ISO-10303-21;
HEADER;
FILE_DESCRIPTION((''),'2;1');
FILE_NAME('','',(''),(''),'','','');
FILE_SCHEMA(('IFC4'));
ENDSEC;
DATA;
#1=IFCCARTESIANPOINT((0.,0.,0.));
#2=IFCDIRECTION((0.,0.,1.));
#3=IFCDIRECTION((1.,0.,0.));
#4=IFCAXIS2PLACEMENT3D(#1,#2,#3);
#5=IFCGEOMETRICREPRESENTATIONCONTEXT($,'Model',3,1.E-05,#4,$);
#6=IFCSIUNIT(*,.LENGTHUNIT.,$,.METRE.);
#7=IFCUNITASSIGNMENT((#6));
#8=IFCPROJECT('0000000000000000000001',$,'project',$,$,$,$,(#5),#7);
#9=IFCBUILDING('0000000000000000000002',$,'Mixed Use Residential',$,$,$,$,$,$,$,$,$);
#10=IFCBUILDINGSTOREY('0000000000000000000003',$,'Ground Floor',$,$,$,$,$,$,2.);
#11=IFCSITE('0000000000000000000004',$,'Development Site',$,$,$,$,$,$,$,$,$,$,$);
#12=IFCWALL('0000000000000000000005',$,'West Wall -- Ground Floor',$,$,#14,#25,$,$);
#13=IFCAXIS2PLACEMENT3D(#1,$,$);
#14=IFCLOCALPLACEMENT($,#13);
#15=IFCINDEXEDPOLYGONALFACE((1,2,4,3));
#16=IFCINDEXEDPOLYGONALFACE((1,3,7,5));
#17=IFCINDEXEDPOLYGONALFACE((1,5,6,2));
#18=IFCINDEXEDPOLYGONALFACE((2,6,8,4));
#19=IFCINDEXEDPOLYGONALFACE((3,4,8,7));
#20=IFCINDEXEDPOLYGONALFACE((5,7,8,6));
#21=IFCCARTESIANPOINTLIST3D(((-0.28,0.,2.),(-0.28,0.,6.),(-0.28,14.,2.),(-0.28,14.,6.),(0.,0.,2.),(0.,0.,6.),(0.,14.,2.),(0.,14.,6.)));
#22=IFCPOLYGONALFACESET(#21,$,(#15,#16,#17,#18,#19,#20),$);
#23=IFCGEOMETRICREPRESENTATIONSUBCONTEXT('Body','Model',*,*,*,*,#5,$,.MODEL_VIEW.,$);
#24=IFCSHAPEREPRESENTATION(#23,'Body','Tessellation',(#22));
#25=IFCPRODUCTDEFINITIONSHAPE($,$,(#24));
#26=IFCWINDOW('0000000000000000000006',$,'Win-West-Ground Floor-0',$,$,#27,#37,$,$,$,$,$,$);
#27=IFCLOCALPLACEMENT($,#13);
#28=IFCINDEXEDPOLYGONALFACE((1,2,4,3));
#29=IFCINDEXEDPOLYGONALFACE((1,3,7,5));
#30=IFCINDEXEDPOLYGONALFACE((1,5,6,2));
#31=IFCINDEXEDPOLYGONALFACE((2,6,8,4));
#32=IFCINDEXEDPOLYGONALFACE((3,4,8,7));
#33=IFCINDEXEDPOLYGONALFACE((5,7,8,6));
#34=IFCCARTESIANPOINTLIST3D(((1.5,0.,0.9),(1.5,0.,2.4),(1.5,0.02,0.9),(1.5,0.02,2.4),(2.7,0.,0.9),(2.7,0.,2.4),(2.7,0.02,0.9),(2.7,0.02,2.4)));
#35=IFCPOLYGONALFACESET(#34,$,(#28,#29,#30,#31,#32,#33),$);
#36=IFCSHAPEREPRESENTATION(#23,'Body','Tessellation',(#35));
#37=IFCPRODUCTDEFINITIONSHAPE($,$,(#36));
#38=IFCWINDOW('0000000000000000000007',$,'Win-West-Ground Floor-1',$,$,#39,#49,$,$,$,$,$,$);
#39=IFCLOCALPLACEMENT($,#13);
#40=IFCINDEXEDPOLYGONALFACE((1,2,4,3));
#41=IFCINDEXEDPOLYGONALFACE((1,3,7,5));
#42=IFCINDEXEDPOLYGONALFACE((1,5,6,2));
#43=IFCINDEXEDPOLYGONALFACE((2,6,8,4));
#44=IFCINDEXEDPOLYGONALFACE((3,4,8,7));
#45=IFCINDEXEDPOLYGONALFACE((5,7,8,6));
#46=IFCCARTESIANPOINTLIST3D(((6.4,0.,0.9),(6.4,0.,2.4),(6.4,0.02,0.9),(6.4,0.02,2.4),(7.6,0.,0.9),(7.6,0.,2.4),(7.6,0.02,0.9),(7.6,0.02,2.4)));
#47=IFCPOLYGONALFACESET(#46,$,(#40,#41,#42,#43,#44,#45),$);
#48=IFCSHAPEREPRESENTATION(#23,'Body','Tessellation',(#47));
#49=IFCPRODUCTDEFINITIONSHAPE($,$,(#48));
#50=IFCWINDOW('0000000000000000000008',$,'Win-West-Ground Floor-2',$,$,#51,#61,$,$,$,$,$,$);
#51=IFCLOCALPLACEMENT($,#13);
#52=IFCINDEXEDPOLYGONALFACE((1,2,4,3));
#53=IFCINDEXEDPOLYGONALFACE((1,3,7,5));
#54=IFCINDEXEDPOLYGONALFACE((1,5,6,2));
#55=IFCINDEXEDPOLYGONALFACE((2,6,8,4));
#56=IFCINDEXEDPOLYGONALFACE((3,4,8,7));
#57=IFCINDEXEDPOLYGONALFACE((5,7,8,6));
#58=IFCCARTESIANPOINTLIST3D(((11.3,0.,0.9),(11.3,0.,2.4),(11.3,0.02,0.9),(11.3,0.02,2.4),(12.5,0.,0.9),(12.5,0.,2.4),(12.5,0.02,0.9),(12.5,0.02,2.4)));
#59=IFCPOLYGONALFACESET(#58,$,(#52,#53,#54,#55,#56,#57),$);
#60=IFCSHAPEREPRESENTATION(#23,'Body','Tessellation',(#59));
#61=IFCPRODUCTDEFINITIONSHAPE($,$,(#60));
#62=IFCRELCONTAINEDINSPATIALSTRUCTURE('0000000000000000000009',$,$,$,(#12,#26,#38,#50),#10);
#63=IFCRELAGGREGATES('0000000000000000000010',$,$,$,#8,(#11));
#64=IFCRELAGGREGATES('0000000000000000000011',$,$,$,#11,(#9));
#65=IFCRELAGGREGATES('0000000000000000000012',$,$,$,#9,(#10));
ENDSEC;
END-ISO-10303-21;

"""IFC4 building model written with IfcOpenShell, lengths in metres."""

from ifc_helpers import new_model, si_unit, frame, origin_with_axes, place, context, subcontext, project, spatial, indexed_curve, outline, extrude, element, fill, save


model = new_model("IFC4")

# Units and contexts
model_context = context("Model", 3, precision=1e-05, world=origin_with_axes())
body_context = subcontext(model_context, "Body", "Model", "MODEL_VIEW")
ifc_project = project(units=[si_unit("LENGTHUNIT", "METRE")], contexts=[model_context])

# Site, building, storey
site = spatial("IfcSite", under=ifc_project, Name="Development Site")
building = spatial("IfcBuilding", under=site, Name="Mixed Use Residential")
storey = spatial("IfcBuildingStorey", under=building, Name="Ground Floor", Elevation=2.0)

# Wall, openings, windows
wall_1_placement = place(None, frame((0.0, 0.0, 2.0), z_axis=(0.0, 0.0, 1.0), x_axis=(0.0, 1.0, 0.0)))
wall_1 = element("IfcWall", 1, at=wall_1_placement, inside=storey, Name="West Wall -- Ground Floor", context=body_context, shape_type="SweptSolid", body=[
    extrude(outline(indexed_curve([(0.0, 0.0), (0.0, 0.28), (14.0, 0.28), (14.0, 0.0), (0.0, 0.0)], self_intersect=False)), origin_with_axes(), (0.0, 0.0, 1.0), 4.0),
])
opening_1_placement = place(wall_1_placement, frame((0.0, -1.5, -1.1), z_axis=(0.0, 0.0, 1.0), x_axis=(0.0, -1.0, 0.0)))
opening_1 = element("IfcOpeningElement", 2, at=opening_1_placement, cuts=wall_1, context=body_context, shape_type="SweptSolid", body=[
    extrude(outline(indexed_curve([(0.0, 0.0), (0.0, 0.28), (1.2, 0.28), (1.2, 0.0), (0.0, 0.0)], self_intersect=False)), origin_with_axes(), (0.0, 0.0, 1.0), 1.5),
])
opening_2_placement = place(wall_1_placement, frame((0.0, -6.4, -1.1), z_axis=(0.0, 0.0, 1.0), x_axis=(0.0, -1.0, 0.0)))
opening_2 = element("IfcOpeningElement", 3, at=opening_2_placement, cuts=wall_1, context=body_context, shape_type="SweptSolid", body=[
    extrude(outline(indexed_curve([(0.0, 0.0), (0.0, 0.28), (1.2, 0.28), (1.2, 0.0), (0.0, 0.0)], self_intersect=False)), origin_with_axes(), (0.0, 0.0, 1.0), 1.5),
])
opening_3_placement = place(wall_1_placement, frame((0.0, -11.3, -1.1), z_axis=(0.0, 0.0, 1.0), x_axis=(0.0, -1.0, 0.0)))
opening_3 = element("IfcOpeningElement", 4, at=opening_3_placement, cuts=wall_1, context=body_context, shape_type="SweptSolid", body=[
    extrude(outline(indexed_curve([(0.0, 0.0), (0.0, 0.28), (1.2, 0.28), (1.2, 0.0), (0.0, 0.0)], self_intersect=False)), origin_with_axes(), (0.0, 0.0, 1.0), 1.5),
])
window_1_placement = place(None, frame((1.5, 0.0, 0.9), z_axis=(0.0, 0.0, 1.0), x_axis=(1.0, 0.0, 0.0)))
window_1 = element("IfcWindow", 5, at=window_1_placement, inside=storey, Name="Win-West-Ground Floor-0", context=body_context, shape_type="SweptSolid", body=[
    extrude(outline(indexed_curve([(0.0, 0.0), (0.0, 0.02), (1.2, 0.02), (1.2, 0.0), (0.0, 0.0)], self_intersect=False)), origin_with_axes(), (0.0, 0.0, 1.0), 1.5),
])
fill(opening_1, window_1)
window_2_placement = place(None, frame((6.4, 0.0, 0.9), z_axis=(0.0, 0.0, 1.0), x_axis=(1.0, 0.0, 0.0)))
window_2 = element("IfcWindow", 6, at=window_2_placement, inside=storey, Name="Win-West-Ground Floor-1", context=body_context, shape_type="SweptSolid", body=[
    extrude(outline(indexed_curve([(0.0, 0.0), (0.0, 0.02), (1.2, 0.02), (1.2, 0.0), (0.0, 0.0)], self_intersect=False)), origin_with_axes(), (0.0, 0.0, 1.0), 1.5),
])
fill(opening_2, window_2)
window_3_placement = place(None, frame((11.3, 0.0, 0.9), z_axis=(0.0, 0.0, 1.0), x_axis=(1.0, 0.0, 0.0)))
window_3 = element("IfcWindow", 7, at=window_3_placement, inside=storey, Name="Win-West-Ground Floor-2", context=body_context, shape_type="SweptSolid", body=[
    extrude(outline(indexed_curve([(0.0, 0.0), (0.0, 0.02), (1.2, 0.02), (1.2, 0.0), (0.0, 0.0)], self_intersect=False)), origin_with_axes(), (0.0, 0.0, 1.0), 1.5),
])
fill(opening_3, window_3)

save(model, "model.ifc")
